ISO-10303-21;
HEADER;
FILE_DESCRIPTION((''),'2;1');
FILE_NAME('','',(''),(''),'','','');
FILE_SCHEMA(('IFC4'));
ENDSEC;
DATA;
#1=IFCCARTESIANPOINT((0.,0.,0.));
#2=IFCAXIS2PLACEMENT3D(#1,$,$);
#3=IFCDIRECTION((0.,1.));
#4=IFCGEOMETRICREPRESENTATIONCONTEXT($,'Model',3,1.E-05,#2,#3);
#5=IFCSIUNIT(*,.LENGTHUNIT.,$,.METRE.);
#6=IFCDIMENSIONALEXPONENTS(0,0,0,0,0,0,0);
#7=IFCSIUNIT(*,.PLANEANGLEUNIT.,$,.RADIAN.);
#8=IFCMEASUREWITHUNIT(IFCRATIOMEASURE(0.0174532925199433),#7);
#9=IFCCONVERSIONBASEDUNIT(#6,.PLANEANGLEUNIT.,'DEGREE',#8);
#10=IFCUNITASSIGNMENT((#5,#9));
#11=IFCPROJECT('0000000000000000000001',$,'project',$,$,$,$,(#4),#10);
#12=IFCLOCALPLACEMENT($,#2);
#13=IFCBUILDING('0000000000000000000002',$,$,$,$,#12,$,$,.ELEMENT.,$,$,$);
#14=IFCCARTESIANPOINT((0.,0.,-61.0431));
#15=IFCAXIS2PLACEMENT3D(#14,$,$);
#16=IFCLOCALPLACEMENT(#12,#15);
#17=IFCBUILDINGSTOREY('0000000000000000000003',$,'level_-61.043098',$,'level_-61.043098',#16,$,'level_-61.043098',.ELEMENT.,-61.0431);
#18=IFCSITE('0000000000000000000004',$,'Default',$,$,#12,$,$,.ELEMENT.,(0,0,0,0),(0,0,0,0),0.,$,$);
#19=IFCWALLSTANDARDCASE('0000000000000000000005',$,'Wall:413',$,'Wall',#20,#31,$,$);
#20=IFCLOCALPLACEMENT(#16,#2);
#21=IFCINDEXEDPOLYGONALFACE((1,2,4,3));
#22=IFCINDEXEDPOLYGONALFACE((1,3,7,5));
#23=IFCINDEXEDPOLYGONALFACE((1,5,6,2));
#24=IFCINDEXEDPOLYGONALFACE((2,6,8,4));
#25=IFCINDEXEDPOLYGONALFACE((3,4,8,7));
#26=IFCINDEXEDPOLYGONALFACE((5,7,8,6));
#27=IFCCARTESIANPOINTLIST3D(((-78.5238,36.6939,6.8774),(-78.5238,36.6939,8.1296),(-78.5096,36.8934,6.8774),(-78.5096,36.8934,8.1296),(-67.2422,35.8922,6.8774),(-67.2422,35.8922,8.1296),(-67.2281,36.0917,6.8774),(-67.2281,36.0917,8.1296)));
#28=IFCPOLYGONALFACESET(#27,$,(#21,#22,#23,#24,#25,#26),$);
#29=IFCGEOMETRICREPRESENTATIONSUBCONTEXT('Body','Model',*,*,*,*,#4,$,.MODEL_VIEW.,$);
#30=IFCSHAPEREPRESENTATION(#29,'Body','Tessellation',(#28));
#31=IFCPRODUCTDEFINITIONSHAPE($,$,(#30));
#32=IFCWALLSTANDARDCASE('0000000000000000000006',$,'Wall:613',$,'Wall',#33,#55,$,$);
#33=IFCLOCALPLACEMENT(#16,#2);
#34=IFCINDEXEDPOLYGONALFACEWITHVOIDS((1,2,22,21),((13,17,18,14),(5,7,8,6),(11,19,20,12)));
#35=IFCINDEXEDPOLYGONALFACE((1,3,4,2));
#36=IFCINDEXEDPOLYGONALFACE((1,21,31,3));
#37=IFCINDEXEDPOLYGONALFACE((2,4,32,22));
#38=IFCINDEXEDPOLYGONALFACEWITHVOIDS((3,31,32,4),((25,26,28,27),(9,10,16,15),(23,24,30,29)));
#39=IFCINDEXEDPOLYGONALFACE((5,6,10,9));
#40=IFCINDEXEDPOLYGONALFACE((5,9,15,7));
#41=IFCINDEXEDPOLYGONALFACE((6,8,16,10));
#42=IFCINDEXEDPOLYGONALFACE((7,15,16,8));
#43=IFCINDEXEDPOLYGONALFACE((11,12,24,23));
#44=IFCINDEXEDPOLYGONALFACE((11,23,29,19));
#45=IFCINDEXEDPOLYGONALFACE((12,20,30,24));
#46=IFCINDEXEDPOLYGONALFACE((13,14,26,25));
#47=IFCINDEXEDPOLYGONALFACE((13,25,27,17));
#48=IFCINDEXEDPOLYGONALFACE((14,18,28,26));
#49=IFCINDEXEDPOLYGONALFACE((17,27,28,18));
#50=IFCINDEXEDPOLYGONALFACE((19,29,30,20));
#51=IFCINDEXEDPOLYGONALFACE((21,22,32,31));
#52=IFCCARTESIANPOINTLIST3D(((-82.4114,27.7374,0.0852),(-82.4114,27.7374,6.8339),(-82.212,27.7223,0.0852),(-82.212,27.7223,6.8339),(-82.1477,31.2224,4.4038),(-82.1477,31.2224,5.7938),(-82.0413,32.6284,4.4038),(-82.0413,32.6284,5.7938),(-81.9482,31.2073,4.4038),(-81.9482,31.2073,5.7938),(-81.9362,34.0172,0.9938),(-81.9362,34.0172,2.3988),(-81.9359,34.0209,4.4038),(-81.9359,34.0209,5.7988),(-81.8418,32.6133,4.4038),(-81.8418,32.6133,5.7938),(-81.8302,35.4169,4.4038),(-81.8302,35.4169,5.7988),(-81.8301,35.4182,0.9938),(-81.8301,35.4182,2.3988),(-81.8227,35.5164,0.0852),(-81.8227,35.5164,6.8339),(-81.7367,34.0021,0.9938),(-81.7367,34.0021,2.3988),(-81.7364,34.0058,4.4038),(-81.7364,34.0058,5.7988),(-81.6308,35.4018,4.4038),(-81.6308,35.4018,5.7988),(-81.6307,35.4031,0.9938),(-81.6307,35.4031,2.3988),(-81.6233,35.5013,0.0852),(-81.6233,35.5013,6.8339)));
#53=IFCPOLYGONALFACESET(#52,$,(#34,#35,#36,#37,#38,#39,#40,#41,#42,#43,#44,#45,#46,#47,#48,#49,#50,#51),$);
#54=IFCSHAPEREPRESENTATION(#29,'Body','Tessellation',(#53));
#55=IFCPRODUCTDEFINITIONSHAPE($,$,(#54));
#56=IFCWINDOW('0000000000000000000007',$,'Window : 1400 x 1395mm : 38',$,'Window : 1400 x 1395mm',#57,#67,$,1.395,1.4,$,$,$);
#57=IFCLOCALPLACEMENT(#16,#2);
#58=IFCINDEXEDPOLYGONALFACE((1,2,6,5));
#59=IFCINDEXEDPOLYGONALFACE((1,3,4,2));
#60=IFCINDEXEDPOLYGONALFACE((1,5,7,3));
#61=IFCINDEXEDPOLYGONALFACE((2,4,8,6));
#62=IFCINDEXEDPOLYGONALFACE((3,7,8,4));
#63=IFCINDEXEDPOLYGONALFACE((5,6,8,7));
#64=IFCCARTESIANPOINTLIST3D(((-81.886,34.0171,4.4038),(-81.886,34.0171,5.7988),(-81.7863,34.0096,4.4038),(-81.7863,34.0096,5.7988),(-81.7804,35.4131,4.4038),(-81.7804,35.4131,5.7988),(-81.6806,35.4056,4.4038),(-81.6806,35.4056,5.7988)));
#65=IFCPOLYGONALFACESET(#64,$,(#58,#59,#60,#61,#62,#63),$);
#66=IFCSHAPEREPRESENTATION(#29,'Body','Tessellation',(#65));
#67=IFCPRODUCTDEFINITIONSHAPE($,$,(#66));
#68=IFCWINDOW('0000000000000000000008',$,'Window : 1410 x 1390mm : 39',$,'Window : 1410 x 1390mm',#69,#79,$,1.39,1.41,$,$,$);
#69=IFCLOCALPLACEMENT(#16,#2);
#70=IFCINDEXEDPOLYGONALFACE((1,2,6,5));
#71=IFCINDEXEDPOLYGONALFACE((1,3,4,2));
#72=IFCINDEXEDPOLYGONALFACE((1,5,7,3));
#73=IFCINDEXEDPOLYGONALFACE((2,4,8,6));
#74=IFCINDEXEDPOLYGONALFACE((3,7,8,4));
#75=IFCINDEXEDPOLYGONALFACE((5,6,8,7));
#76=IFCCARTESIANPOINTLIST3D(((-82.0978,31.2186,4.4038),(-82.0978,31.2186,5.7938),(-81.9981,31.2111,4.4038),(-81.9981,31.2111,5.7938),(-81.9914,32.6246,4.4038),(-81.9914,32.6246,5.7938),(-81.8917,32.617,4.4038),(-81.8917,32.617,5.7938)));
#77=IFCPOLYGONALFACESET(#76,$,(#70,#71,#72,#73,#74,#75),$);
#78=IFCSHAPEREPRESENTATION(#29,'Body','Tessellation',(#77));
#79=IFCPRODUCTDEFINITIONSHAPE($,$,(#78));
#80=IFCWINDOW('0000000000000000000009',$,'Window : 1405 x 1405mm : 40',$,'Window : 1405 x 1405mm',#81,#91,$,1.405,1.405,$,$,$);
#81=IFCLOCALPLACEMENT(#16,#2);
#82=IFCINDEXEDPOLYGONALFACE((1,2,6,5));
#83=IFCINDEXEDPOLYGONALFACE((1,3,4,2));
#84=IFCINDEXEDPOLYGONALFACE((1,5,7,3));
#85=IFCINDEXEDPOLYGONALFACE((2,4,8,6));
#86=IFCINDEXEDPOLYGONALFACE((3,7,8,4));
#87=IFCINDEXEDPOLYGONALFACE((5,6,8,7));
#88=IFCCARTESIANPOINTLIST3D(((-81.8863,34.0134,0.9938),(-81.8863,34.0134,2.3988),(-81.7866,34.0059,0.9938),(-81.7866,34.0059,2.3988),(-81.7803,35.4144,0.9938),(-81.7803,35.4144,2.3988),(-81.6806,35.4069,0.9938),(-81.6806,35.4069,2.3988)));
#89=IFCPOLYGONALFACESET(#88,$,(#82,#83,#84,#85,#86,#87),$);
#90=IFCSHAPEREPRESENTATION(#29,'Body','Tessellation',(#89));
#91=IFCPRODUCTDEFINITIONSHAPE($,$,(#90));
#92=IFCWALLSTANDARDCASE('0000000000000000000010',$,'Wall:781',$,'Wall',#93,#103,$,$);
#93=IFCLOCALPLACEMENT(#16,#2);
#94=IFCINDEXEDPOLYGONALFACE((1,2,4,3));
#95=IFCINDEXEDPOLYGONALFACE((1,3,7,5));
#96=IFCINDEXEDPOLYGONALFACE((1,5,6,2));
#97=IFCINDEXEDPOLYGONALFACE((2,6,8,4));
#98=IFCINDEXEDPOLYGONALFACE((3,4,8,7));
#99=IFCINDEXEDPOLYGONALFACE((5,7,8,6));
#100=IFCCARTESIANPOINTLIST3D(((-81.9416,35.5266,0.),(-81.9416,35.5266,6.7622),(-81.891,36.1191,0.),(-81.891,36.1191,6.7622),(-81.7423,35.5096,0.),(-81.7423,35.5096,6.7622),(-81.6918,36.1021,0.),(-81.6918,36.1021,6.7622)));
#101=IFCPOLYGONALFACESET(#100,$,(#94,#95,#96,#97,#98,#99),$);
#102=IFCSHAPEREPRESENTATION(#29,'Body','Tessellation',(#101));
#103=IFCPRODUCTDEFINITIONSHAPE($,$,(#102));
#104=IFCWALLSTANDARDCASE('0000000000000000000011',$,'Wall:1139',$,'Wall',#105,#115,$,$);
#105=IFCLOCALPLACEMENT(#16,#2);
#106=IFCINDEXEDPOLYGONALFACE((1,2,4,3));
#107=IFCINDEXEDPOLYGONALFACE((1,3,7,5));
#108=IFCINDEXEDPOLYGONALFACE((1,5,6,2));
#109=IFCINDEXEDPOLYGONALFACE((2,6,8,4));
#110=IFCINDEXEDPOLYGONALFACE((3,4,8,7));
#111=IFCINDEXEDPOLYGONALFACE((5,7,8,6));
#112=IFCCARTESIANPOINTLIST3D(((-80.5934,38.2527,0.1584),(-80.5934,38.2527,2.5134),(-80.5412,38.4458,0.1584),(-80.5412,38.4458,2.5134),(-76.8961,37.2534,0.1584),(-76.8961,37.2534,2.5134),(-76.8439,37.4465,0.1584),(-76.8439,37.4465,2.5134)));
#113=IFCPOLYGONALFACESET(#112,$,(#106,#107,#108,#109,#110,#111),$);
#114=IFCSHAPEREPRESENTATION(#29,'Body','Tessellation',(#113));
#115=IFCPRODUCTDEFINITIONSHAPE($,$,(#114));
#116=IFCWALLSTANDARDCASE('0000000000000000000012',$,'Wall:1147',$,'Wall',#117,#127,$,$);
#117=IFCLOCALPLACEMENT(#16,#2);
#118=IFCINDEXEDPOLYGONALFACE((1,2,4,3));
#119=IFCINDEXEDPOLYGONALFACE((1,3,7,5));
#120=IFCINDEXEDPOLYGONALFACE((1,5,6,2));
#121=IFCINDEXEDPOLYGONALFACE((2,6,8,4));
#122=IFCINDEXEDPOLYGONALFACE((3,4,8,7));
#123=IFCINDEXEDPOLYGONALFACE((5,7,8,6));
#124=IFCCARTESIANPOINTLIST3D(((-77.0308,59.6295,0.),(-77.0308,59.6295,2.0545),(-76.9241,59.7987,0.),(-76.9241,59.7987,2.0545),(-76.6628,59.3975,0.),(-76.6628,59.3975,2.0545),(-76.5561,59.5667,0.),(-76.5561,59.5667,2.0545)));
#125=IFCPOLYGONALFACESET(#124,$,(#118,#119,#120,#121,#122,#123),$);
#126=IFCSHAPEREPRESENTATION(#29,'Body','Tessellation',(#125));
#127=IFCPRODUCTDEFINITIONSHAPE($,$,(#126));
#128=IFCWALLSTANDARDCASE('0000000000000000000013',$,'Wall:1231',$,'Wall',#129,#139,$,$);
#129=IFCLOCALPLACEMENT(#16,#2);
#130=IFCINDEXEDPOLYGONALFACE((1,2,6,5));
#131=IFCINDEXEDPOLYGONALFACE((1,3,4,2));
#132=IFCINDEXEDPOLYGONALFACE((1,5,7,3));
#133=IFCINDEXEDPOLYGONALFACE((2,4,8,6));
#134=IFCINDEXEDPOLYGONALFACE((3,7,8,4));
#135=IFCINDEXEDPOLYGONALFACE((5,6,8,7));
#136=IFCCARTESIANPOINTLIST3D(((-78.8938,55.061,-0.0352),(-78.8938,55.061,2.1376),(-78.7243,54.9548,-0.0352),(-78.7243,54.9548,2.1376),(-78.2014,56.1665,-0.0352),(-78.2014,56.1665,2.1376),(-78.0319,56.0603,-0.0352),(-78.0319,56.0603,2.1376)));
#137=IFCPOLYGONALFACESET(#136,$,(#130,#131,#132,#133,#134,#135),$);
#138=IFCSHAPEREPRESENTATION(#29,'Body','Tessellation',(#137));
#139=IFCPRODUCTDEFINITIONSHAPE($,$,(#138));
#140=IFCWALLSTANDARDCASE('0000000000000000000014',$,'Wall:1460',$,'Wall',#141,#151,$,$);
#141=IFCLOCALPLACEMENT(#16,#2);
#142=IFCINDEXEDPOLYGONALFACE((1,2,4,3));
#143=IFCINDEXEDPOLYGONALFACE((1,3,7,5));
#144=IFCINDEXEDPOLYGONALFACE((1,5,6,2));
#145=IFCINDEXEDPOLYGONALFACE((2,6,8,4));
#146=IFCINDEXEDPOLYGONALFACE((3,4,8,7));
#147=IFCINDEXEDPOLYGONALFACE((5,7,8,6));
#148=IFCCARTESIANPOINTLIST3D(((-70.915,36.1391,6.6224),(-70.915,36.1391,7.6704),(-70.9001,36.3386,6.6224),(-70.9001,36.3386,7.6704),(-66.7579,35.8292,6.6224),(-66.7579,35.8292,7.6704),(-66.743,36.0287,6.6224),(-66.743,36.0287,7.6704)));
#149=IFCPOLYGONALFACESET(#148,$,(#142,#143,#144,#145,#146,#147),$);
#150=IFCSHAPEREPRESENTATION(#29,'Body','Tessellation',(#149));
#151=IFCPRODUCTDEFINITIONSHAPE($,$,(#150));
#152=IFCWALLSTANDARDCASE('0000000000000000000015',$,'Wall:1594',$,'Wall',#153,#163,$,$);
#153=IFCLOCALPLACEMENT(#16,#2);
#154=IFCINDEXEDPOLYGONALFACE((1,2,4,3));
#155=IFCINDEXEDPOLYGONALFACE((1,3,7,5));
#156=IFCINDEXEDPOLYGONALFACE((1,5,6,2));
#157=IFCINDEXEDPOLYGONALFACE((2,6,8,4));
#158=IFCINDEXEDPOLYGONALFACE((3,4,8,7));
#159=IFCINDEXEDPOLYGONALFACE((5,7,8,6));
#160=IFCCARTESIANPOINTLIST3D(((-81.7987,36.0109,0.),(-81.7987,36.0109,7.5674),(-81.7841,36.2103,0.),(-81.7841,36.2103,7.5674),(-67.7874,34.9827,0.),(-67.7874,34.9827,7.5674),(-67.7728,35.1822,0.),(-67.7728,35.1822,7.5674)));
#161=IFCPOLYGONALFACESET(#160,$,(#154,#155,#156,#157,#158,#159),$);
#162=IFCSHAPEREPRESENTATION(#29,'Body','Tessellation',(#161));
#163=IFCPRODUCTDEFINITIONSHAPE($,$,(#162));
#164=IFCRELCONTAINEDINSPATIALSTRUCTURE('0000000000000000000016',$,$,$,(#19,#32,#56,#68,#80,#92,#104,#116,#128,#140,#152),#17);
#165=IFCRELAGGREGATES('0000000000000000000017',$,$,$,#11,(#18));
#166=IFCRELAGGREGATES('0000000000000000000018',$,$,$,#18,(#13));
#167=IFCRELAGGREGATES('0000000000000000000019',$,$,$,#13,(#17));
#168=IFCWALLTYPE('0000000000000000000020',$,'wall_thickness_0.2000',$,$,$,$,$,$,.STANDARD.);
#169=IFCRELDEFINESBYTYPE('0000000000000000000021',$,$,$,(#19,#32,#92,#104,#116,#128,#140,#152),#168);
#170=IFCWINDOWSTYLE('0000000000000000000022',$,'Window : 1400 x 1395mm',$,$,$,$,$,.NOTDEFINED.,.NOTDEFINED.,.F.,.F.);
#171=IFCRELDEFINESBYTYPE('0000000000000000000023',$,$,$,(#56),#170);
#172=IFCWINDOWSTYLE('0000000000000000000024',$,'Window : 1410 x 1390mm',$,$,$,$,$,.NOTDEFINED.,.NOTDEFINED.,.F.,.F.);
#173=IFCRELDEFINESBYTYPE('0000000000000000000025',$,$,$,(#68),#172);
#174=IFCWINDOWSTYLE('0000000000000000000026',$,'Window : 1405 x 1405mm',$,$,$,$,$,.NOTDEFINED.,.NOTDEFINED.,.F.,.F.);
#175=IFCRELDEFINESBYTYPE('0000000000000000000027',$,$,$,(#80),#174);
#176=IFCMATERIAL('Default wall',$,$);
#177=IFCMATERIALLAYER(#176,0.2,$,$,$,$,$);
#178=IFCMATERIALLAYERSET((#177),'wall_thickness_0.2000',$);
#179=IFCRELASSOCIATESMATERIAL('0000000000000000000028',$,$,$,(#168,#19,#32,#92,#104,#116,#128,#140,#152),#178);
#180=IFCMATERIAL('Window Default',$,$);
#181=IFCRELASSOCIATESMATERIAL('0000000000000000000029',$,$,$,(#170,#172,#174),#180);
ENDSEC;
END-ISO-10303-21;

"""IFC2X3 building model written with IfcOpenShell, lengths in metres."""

from ifc_helpers import new_model, entity, si_unit, converted_unit, direction, frame, frame_2d, origin, origin_2d_with_axis, place, context, subcontext, project, spatial, polyline, rectangle, outline, extrude, source, transform, mapped, material, layer, layer_set, layer_usage, type_object, type_shapes, element, fill, save


model = new_model("IFC2X3")

# Units and contexts
model_context = context("Model", 3, precision=1e-05, world=origin(), true_north=direction((0.0, 1.0)))
body_context = subcontext(model_context, "Body", "Model", "MODEL_VIEW")
ifc_project = project(units=[si_unit("LENGTHUNIT", "METRE"), converted_unit("PLANEANGLEUNIT", "DEGREE", entity("IfcRatioMeasure", 0.0174532925199433), si_unit("PLANEANGLEUNIT", "RADIAN"), dimensions=[0, 0, 0, 0, 0, 0, 0])], contexts=[model_context])

# Site, building, storey
placement_1 = place(None, origin())
site = spatial("IfcSite", under=ifc_project, at=placement_1, Name="Default", CompositionType="ELEMENT", RefLatitude=(0, 0, 0, 0), RefLongitude=(0, 0, 0, 0), RefElevation=0.0)
building = spatial("IfcBuilding", under=site, at=placement_1, CompositionType="ELEMENT")
storey_placement = place(placement_1, frame((0.0, 0.0, -61.0431)))
storey = spatial("IfcBuildingStorey", under=building, at=storey_placement, Name="level_-61.043098", ObjectType="level_-61.043098", LongName="level_-61.043098", CompositionType="ELEMENT", Elevation=-61.0431)

# Wall
ifc_material_1 = material(Name="Default wall")
ifc_layer = layer(ifc_material_1, 0.2)
ifc_layer_set = layer_set([ifc_layer], Name="wall_thickness_0.2000")
ifc_layer_usage = layer_usage(ifc_layer_set, "AXIS2", "POSITIVE", -0.1)
wall_type = type_object("IfcWallType", Name="wall_thickness_0.2000", PredefinedType="STANDARD", material=ifc_layer_set)
placement_2 = place(placement_1, frame((0.0, 0.0, -54.1657)))
wall_1_placement = place(placement_2, frame((-78.5167, 36.7937, 0.0), z_axis=(0.0, 0.0, 1.0), x_axis=(0.997484, -0.070889, 0.0)))
element("IfcWallStandardCase", 1, at=wall_1_placement, inside=storey, type_object=wall_type, material=ifc_layer_usage, Name="Wall:413", ObjectType="Wall", context=body_context, shape_type="SweptSolid", body=[
    extrude(outline(polyline([(11.31, -0.1), (11.31, 0.1), (0.0, 0.1), (0.0, -0.1), (11.31, -0.1)])), origin(), (0.0, 0.0, 1.0), 1.2522),
])

# Wall, openings, windows
placement_3 = place(placement_1, frame((0.0, 0.0, -60.9579)))
wall_2_placement = place(placement_3, frame((-81.723, 35.5088, 0.0), z_axis=(0.0, 0.0, 1.0), x_axis=(-0.075467, -0.997148, 0.0)))
wall_2 = element("IfcWallStandardCase", 2, at=wall_2_placement, inside=storey, type_object=wall_type, material=ifc_layer_usage, Name="Wall:613", ObjectType="Wall", context=body_context, shape_type="SweptSolid", body=[
    extrude(outline(polyline([(7.8013, -0.1), (7.8013, 0.1), (0.0, 0.1), (0.0, -0.1), (7.8013, -0.1)])), origin(), (0.0, 0.0, 1.0), 6.7487),
])
opening_1_placement = place(wall_2_placement, frame((0.0998, -0.1, 4.3186)))
opening_1 = element("IfcOpeningElement", 3, at=opening_1_placement, cuts=wall_2, ObjectType="Opening", context=body_context, shape_type="SweptSolid", body=[
    extrude(rectangle(XDim=1.4, YDim=1.395, at=frame_2d((0.6975, 0.7), x_axis=(0.0, 1.0))), frame((0.0, 0.0, 0.0), z_axis=(0.0, 1.0, 0.0), x_axis=(0.0, 0.0, 1.0)), (0.0, 0.0, 1.0), 0.2),
])
opening_2_placement = place(wall_2_placement, frame((2.8963, -0.1, 4.3186)))
opening_2 = element("IfcOpeningElement", 4, at=opening_2_placement, cuts=wall_2, ObjectType="Opening", context=body_context, shape_type="SweptSolid", body=[
    extrude(rectangle(XDim=1.41, YDim=1.39, at=frame_2d((0.695, 0.705), x_axis=(0.0, 1.0))), frame((0.0, 0.0, 0.0), z_axis=(0.0, 1.0, 0.0), x_axis=(0.0, 0.0, 1.0)), (0.0, 0.0, 1.0), 0.2),
])
opening_3_placement = place(wall_2_placement, frame((0.0985, -0.1, 0.9086)))
opening_3 = element("IfcOpeningElement", 5, at=opening_3_placement, cuts=wall_2, ObjectType="Opening", context=body_context, shape_type="SweptSolid", body=[
    extrude(rectangle(XDim=1.405, YDim=1.405, at=frame_2d((0.7025, 0.7025), x_axis=(0.0, 1.0))), frame((0.0, 0.0, 0.0), z_axis=(0.0, 1.0, 0.0), x_axis=(0.0, 0.0, 1.0)), (0.0, 0.0, 1.0), 0.2),
])
ifc_material_2 = material(Name="Window Default")
window_style_1 = type_object("IfcWindowStyle", Name="Window : 1400 x 1395mm", ConstructionType="NOTDEFINED", OperationType="NOTDEFINED", ParameterTakesPrecedence=False, Sizeable=False, material=ifc_material_2)
shared_shape_1 = source(origin(), body_context, "Body", "SweptSolid", [
    extrude(rectangle(XDim=0.1, YDim=1.4, at=origin_2d_with_axis()), frame((0.7, 0.1, 0.0), z_axis=(0.0, 0.0, 1.0), x_axis=(0.0, 1.0, 0.0)), (0.0, 0.0, 1.0), 1.395),
])
type_shapes(window_style_1, [shared_shape_1])
window_1_placement = place(opening_1_placement, origin())
window_1 = element("IfcWindow", 6, at=window_1_placement, inside=storey, type_object=window_style_1, Name="Window : 1400 x 1395mm : 38", ObjectType="Window : 1400 x 1395mm", OverallHeight=1.395, OverallWidth=1.4, context=body_context, shape_type="MappedRepresentation", body=[
    mapped(shared_shape_1, transform((0.0, 0.0, 0.0), scale=1.0)),
])
fill(opening_1, window_1)
window_style_2 = type_object("IfcWindowStyle", Name="Window : 1410 x 1390mm", ConstructionType="NOTDEFINED", OperationType="NOTDEFINED", ParameterTakesPrecedence=False, Sizeable=False, material=ifc_material_2)
shared_shape_2 = source(origin(), body_context, "Body", "SweptSolid", [
    extrude(rectangle(XDim=0.1, YDim=1.41, at=origin_2d_with_axis()), frame((0.705, 0.1, 0.0), z_axis=(0.0, 0.0, 1.0), x_axis=(0.0, 1.0, 0.0)), (0.0, 0.0, 1.0), 1.39),
])
type_shapes(window_style_2, [shared_shape_2])
window_2_placement = place(opening_2_placement, origin())
window_2 = element("IfcWindow", 7, at=window_2_placement, inside=storey, type_object=window_style_2, Name="Window : 1410 x 1390mm : 39", ObjectType="Window : 1410 x 1390mm", OverallHeight=1.39, OverallWidth=1.41, context=body_context, shape_type="MappedRepresentation", body=[
    mapped(shared_shape_2, transform((0.0, 0.0, 0.0), scale=1.0)),
])
fill(opening_2, window_2)
window_style_3 = type_object("IfcWindowStyle", Name="Window : 1405 x 1405mm", ConstructionType="NOTDEFINED", OperationType="NOTDEFINED", ParameterTakesPrecedence=False, Sizeable=False, material=ifc_material_2)
shared_shape_3 = source(origin(), body_context, "Body", "SweptSolid", [
    extrude(rectangle(XDim=0.1, YDim=1.405, at=origin_2d_with_axis()), frame((0.7025, 0.1, 0.0), z_axis=(0.0, 0.0, 1.0), x_axis=(0.0, 1.0, 0.0)), (0.0, 0.0, 1.0), 1.405),
])
type_shapes(window_style_3, [shared_shape_3])
window_3_placement = place(opening_3_placement, origin())
window_3 = element("IfcWindow", 8, at=window_3_placement, inside=storey, type_object=window_style_3, Name="Window : 1405 x 1405mm : 40", ObjectType="Window : 1405 x 1405mm", OverallHeight=1.405, OverallWidth=1.405, context=body_context, shape_type="MappedRepresentation", body=[
    mapped(shared_shape_3, transform((0.0, 0.0, 0.0), scale=1.0)),
])
fill(opening_3, window_3)

# Walls
wall_3_placement = place(storey_placement, frame((-81.842, 35.5181, 0.0), z_axis=(0.0, 0.0, 1.0), x_axis=(0.085028, 0.996379, 0.0)))
element("IfcWallStandardCase", 9, at=wall_3_placement, inside=storey, type_object=wall_type, material=ifc_layer_usage, Name="Wall:781", ObjectType="Wall", context=body_context, shape_type="SweptSolid", body=[
    extrude(outline(polyline([(0.5946, -0.1), (0.5946, 0.1), (0.0, 0.1), (0.0, -0.1), (0.5946, -0.1)])), origin(), (0.0, 0.0, 1.0), 6.7622),
])
placement_4 = place(placement_1, frame((0.0, 0.0, -60.8847)))
wall_4_placement = place(placement_4, frame((-80.5673, 38.3493, 0.0), z_axis=(0.0, 0.0, 1.0), x_axis=(0.965364, -0.260907, 0.0)))
element("IfcWallStandardCase", 10, at=wall_4_placement, inside=storey, type_object=wall_type, material=ifc_layer_usage, Name="Wall:1139", ObjectType="Wall", context=body_context, shape_type="SweptSolid", body=[
    extrude(outline(polyline([(3.83, -0.1), (3.83, 0.1), (0.0, 0.1), (0.0, -0.1), (3.83, -0.1)])), origin(), (0.0, 0.0, 1.0), 2.3551),
])
wall_5_placement = place(storey_placement, frame((-76.9774, 59.7141, 0.0), z_axis=(0.0, 0.0, 1.0), x_axis=(0.845923, -0.533306, 0.0)))
element("IfcWallStandardCase", 11, at=wall_5_placement, inside=storey, type_object=wall_type, material=ifc_layer_usage, Name="Wall:1147", ObjectType="Wall", context=body_context, shape_type="SweptSolid", body=[
    extrude(outline(polyline([(0.435, -0.1), (0.435, 0.1), (0.0, 0.1), (0.0, -0.1), (0.435, -0.1)])), origin(), (0.0, 0.0, 1.0), 2.0545),
])
placement_5 = place(placement_1, frame((0.0, 0.0, -61.0783)))
wall_6_placement = place(placement_5, frame((-78.1166, 56.1134, 0.0), z_axis=(0.0, 0.0, 1.0), x_axis=(-0.530829, -0.847479, 0.0)))
element("IfcWallStandardCase", 12, at=wall_6_placement, inside=storey, type_object=wall_type, material=ifc_layer_usage, Name="Wall:1231", ObjectType="Wall", context=body_context, shape_type="SweptSolid", body=[
    extrude(outline(polyline([(1.3044, -0.1), (1.3044, 0.1), (0.0, 0.1), (0.0, -0.1), (1.3044, -0.1)])), origin(), (0.0, 0.0, 1.0), 2.1728),
])
placement_6 = place(placement_1, frame((0.0, 0.0, -54.4207)))
wall_7_placement = place(placement_6, frame((-70.9076, 36.2389, 0.0), z_axis=(0.0, 0.0, 1.0), x_axis=(0.997233, -0.074341, 0.0)))
element("IfcWallStandardCase", 13, at=wall_7_placement, inside=storey, type_object=wall_type, material=ifc_layer_usage, Name="Wall:1460", ObjectType="Wall", context=body_context, shape_type="SweptSolid", body=[
    extrude(outline(polyline([(4.1687, -0.1), (4.1687, 0.1), (0.0, 0.1), (0.0, -0.1), (4.1687, -0.1)])), origin(), (0.0, 0.0, 1.0), 1.048),
])
wall_8_placement = place(storey_placement, frame((-81.7914, 36.1106, 0.0), z_axis=(0.0, 0.0, 1.0), x_axis=(0.997318, -0.073186, 0.0)))
element("IfcWallStandardCase", 14, at=wall_8_placement, inside=storey, type_object=wall_type, material=ifc_layer_usage, Name="Wall:1594", ObjectType="Wall", context=body_context, shape_type="SweptSolid", body=[
    extrude(outline(polyline([(14.0489, -0.1), (14.0489, 0.1), (0.0, 0.1), (0.0, -0.1), (14.0489, -0.1)])), origin(), (0.0, 0.0, 1.0), 7.5674),
])

save(model, "model.ifc")
